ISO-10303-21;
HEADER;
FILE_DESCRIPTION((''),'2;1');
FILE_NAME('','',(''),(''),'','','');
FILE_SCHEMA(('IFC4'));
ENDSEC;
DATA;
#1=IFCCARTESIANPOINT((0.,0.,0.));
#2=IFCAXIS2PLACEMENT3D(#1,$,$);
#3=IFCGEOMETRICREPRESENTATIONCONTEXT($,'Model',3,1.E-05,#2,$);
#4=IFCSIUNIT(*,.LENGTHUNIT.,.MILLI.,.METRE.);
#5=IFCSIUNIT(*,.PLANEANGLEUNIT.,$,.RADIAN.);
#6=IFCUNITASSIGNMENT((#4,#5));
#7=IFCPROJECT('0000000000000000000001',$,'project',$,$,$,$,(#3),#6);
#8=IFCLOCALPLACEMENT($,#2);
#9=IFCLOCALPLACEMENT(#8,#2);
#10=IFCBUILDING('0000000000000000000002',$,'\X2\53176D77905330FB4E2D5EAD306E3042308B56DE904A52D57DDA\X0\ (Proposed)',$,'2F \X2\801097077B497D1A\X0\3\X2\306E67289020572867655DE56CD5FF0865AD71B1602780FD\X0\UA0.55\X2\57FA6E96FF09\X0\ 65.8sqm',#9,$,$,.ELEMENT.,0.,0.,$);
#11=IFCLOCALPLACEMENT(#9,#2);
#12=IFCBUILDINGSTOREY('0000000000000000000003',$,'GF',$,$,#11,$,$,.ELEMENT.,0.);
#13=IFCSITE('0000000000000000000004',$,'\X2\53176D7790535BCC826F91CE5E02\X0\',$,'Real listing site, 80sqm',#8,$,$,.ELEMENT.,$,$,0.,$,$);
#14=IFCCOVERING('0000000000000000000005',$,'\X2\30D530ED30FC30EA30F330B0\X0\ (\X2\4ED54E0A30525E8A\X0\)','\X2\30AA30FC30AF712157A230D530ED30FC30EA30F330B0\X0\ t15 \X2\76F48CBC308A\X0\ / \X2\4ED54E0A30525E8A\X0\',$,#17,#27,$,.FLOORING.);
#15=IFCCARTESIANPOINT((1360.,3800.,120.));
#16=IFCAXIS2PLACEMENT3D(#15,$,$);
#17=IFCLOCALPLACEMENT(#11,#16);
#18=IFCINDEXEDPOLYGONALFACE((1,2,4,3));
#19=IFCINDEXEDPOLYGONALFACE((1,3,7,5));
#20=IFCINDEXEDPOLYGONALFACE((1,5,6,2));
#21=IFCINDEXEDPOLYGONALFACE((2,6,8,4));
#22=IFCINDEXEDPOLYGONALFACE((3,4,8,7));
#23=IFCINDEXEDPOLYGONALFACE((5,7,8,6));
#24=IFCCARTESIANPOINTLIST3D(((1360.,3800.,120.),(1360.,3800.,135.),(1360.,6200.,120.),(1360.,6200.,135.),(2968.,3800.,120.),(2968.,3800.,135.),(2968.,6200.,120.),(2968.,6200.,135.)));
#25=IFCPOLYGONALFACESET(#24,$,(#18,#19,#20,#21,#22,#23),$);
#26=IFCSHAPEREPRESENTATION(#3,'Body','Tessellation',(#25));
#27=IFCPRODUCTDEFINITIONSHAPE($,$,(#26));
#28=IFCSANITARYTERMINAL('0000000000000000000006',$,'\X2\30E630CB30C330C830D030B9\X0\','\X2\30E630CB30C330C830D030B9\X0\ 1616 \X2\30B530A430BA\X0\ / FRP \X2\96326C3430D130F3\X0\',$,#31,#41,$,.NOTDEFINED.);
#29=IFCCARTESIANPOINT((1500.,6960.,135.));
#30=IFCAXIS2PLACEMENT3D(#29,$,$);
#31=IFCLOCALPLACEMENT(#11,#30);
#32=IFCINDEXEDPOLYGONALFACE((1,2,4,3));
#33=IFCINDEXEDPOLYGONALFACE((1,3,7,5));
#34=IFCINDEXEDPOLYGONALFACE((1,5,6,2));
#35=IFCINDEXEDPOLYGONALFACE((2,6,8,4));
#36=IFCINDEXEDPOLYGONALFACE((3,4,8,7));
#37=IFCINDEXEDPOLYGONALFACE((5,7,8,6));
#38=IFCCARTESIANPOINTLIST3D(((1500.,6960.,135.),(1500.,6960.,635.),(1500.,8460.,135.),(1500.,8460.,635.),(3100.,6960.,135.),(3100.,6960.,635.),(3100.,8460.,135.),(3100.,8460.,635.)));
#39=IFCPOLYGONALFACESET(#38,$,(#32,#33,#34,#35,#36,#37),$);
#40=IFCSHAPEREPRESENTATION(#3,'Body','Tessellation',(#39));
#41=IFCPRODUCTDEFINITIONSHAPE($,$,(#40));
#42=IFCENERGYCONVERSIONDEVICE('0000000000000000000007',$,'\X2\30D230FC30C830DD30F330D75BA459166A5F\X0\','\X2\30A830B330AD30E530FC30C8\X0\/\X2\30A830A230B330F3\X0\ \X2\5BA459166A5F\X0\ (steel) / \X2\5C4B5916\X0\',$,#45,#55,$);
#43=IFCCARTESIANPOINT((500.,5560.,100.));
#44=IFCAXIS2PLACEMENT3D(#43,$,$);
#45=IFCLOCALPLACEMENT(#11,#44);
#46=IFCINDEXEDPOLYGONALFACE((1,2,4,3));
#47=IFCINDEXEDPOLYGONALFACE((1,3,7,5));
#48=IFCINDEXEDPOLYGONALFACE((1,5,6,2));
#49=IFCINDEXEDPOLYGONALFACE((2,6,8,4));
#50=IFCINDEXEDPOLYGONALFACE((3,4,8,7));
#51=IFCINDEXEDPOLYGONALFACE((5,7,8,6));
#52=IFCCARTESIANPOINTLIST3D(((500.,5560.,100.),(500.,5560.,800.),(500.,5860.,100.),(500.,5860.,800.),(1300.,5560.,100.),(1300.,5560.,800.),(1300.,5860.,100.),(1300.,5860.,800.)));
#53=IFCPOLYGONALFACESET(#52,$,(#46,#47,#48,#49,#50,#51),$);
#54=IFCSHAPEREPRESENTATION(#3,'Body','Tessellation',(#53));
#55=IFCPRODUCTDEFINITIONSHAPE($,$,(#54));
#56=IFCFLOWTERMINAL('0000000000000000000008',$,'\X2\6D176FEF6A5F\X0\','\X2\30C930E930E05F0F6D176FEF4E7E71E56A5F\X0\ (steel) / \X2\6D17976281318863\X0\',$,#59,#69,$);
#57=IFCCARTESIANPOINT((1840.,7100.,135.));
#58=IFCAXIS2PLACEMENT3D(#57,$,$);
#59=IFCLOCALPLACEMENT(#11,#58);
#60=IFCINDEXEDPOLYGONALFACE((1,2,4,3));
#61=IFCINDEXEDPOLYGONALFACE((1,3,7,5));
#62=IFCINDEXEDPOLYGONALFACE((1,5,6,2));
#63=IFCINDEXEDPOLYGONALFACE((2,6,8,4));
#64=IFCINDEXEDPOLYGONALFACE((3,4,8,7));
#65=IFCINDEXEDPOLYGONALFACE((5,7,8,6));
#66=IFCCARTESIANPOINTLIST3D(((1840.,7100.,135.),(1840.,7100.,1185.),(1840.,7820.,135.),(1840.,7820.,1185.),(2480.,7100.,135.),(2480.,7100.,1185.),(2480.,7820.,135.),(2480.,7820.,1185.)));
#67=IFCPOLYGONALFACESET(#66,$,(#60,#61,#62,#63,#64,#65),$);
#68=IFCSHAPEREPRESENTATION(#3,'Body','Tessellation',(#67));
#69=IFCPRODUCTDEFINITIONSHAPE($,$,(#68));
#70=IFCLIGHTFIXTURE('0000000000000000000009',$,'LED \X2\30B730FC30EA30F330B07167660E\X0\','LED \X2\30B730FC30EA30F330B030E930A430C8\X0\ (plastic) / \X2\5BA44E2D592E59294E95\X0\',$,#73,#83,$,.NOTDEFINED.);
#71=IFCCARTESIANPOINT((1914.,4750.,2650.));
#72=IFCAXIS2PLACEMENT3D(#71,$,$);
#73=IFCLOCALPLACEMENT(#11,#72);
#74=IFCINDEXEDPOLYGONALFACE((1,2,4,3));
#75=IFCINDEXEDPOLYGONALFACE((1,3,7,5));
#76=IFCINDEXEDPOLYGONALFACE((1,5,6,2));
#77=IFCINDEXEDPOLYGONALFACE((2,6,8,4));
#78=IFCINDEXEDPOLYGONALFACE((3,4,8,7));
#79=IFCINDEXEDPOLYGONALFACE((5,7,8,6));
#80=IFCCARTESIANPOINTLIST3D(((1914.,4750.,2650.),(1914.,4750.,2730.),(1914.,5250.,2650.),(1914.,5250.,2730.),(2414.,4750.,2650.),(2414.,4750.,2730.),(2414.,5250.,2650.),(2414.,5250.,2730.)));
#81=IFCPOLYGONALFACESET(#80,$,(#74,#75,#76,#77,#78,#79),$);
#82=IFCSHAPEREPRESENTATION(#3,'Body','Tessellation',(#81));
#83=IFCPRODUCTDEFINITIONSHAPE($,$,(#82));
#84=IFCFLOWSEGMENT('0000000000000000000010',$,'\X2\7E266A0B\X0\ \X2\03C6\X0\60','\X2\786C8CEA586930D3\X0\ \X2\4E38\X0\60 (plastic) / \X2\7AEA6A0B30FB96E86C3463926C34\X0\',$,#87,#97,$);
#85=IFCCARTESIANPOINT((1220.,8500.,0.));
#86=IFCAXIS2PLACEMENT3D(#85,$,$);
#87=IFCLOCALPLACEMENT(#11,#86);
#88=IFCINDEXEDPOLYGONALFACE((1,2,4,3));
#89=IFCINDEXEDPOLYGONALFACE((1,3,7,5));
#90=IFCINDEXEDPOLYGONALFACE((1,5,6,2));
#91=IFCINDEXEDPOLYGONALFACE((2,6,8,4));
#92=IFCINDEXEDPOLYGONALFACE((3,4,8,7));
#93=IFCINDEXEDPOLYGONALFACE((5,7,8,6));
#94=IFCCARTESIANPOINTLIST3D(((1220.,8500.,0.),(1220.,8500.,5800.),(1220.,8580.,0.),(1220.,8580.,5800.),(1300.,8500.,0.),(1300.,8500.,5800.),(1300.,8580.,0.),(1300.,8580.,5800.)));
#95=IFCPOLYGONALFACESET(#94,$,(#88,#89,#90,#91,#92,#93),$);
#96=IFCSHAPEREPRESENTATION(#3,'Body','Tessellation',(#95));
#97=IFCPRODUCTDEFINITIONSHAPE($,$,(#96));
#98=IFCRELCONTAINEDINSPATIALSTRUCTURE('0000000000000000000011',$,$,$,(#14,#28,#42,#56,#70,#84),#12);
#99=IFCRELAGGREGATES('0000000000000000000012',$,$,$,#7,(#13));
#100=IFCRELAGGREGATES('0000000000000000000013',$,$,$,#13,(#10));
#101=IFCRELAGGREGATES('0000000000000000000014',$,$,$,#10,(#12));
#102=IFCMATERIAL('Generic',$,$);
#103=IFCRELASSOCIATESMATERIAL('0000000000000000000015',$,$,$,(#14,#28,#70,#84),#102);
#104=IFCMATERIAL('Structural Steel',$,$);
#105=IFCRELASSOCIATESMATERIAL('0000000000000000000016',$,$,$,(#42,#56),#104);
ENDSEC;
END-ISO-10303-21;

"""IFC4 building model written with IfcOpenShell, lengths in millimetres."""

from ifc_helpers import new_model, si_unit, frame, frame_2d, origin, place, context, project, spatial, rectangle, extrude, material, element, save


model = new_model("IFC4")

# Units and contexts
model_context = context("Model", 3, precision=1e-05, world=origin())
ifc_project = project(units=[si_unit("LENGTHUNIT", "METRE", prefix="MILLI"), si_unit("PLANEANGLEUNIT", "RADIAN")], contexts=[model_context])

# Site, building, storey
site_placement = place(None, origin())
site = spatial("IfcSite", under=ifc_project, at=site_placement, Name="北海道富良野市", ObjectType="Real listing site, 80sqm", CompositionType="ELEMENT", RefElevation=0.0)
building_placement = place(site_placement, origin())
building = spatial("IfcBuilding", under=site, at=building_placement, Name="北海道・中庭のある回遊動線 (Proposed)", ObjectType="2F 耐震等級3の木造在来工法（断熱性能UA0.55基準） 65.8sqm", CompositionType="ELEMENT", ElevationOfRefHeight=0.0, ElevationOfTerrain=0.0)
storey_placement = place(building_placement, origin())
storey = spatial("IfcBuildingStorey", under=building, at=storey_placement, Name="GF", CompositionType="ELEMENT", Elevation=0.0)

# Covering
ifc_material_1 = material(Name="Generic")
covering_1_placement = place(storey_placement, frame((1360.0, 3800.0, 120.0)))
element("IfcCovering", 1, at=covering_1_placement, inside=storey, material=ifc_material_1, Name="フローリング (仕上げ床)", Description="オーク無垢フローリング t15 直貼り / 仕上げ床", PredefinedType="FLOORING", context=model_context, shape_type="SweptSolid", body=[
    extrude(rectangle(XDim=1608.0, YDim=2400.0, at=frame_2d((804.0, 1200.0))), frame((1360.0, 3800.0, 120.0)), (0.0, 0.0, 1.0), 15.0),
])

# Sanitary terminal
sanitary_terminal_placement = place(storey_placement, frame((1500.0, 6960.0, 135.0)))
element("IfcSanitaryTerminal", 2, at=sanitary_terminal_placement, inside=storey, material=ifc_material_1, Name="ユニットバス", Description="ユニットバス 1616 サイズ / FRP 防水パン", PredefinedType="NOTDEFINED", context=model_context, shape_type="SweptSolid", body=[
    extrude(rectangle(XDim=1600.0, YDim=1500.0, at=frame_2d((800.0, 750.0))), frame((1500.0, 6960.0, 135.0)), (0.0, 0.0, 1.0), 500.0),
])

# Shared definitions
ifc_material_2 = material(Name="Structural Steel")

# Energy conversion device
energy_conversion_device_placement = place(storey_placement, frame((500.0, 5560.0, 100.0)))
element("IfcEnergyConversionDevice", 3, at=energy_conversion_device_placement, inside=storey, material=ifc_material_2, Name="ヒートポンプ室外機", Description="エコキュート/エアコン 室外機 (steel) / 屋外", context=model_context, shape_type="SweptSolid", body=[
    extrude(rectangle(XDim=800.0, YDim=300.0, at=frame_2d((400.0, 150.0))), frame((500.0, 5560.0, 100.0)), (0.0, 0.0, 1.0), 700.0),
])

# Flow terminal
flow_terminal_placement = place(storey_placement, frame((1840.0, 7100.0, 135.0)))
element("IfcFlowTerminal", 4, at=flow_terminal_placement, inside=storey, material=ifc_material_2, Name="洗濯機", Description="ドラム式洗濯乾燥機 (steel) / 洗面脱衣", context=model_context, shape_type="SweptSolid", body=[
    extrude(rectangle(XDim=640.0, YDim=720.0, at=frame_2d((320.0, 360.0))), frame((1840.0, 7100.0, 135.0)), (0.0, 0.0, 1.0), 1050.0),
])

# Light fixture
light_fixture_placement = place(storey_placement, frame((1914.0, 4750.0, 2650.0)))
element("IfcLightFixture", 5, at=light_fixture_placement, inside=storey, material=ifc_material_1, Name="LED シーリング照明", Description="LED シーリングライト (plastic) / 室中央天井", PredefinedType="NOTDEFINED", context=model_context, shape_type="SweptSolid", body=[
    extrude(rectangle(XDim=500.0, YDim=500.0, at=frame_2d((250.0, 250.0))), frame((1914.0, 4750.0, 2650.0)), (0.0, 0.0, 1.0), 80.0),
])

# Flow segment
flow_segment_placement = place(storey_placement, frame((1220.0, 8500.0, 0.0)))
element("IfcFlowSegment", 6, at=flow_segment_placement, inside=storey, material=ifc_material_1, Name="縦樋 φ60", Description="硬質塩ビ 丸60 (plastic) / 竪樋・雨水排水", context=model_context, shape_type="SweptSolid", body=[
    extrude(rectangle(XDim=80.0, YDim=80.0, at=frame_2d((40.0, 40.0))), frame((1220.0, 8500.0, 0.0)), (0.0, 0.0, 1.0), 5800.0),
])

save(model, "model.ifc")
